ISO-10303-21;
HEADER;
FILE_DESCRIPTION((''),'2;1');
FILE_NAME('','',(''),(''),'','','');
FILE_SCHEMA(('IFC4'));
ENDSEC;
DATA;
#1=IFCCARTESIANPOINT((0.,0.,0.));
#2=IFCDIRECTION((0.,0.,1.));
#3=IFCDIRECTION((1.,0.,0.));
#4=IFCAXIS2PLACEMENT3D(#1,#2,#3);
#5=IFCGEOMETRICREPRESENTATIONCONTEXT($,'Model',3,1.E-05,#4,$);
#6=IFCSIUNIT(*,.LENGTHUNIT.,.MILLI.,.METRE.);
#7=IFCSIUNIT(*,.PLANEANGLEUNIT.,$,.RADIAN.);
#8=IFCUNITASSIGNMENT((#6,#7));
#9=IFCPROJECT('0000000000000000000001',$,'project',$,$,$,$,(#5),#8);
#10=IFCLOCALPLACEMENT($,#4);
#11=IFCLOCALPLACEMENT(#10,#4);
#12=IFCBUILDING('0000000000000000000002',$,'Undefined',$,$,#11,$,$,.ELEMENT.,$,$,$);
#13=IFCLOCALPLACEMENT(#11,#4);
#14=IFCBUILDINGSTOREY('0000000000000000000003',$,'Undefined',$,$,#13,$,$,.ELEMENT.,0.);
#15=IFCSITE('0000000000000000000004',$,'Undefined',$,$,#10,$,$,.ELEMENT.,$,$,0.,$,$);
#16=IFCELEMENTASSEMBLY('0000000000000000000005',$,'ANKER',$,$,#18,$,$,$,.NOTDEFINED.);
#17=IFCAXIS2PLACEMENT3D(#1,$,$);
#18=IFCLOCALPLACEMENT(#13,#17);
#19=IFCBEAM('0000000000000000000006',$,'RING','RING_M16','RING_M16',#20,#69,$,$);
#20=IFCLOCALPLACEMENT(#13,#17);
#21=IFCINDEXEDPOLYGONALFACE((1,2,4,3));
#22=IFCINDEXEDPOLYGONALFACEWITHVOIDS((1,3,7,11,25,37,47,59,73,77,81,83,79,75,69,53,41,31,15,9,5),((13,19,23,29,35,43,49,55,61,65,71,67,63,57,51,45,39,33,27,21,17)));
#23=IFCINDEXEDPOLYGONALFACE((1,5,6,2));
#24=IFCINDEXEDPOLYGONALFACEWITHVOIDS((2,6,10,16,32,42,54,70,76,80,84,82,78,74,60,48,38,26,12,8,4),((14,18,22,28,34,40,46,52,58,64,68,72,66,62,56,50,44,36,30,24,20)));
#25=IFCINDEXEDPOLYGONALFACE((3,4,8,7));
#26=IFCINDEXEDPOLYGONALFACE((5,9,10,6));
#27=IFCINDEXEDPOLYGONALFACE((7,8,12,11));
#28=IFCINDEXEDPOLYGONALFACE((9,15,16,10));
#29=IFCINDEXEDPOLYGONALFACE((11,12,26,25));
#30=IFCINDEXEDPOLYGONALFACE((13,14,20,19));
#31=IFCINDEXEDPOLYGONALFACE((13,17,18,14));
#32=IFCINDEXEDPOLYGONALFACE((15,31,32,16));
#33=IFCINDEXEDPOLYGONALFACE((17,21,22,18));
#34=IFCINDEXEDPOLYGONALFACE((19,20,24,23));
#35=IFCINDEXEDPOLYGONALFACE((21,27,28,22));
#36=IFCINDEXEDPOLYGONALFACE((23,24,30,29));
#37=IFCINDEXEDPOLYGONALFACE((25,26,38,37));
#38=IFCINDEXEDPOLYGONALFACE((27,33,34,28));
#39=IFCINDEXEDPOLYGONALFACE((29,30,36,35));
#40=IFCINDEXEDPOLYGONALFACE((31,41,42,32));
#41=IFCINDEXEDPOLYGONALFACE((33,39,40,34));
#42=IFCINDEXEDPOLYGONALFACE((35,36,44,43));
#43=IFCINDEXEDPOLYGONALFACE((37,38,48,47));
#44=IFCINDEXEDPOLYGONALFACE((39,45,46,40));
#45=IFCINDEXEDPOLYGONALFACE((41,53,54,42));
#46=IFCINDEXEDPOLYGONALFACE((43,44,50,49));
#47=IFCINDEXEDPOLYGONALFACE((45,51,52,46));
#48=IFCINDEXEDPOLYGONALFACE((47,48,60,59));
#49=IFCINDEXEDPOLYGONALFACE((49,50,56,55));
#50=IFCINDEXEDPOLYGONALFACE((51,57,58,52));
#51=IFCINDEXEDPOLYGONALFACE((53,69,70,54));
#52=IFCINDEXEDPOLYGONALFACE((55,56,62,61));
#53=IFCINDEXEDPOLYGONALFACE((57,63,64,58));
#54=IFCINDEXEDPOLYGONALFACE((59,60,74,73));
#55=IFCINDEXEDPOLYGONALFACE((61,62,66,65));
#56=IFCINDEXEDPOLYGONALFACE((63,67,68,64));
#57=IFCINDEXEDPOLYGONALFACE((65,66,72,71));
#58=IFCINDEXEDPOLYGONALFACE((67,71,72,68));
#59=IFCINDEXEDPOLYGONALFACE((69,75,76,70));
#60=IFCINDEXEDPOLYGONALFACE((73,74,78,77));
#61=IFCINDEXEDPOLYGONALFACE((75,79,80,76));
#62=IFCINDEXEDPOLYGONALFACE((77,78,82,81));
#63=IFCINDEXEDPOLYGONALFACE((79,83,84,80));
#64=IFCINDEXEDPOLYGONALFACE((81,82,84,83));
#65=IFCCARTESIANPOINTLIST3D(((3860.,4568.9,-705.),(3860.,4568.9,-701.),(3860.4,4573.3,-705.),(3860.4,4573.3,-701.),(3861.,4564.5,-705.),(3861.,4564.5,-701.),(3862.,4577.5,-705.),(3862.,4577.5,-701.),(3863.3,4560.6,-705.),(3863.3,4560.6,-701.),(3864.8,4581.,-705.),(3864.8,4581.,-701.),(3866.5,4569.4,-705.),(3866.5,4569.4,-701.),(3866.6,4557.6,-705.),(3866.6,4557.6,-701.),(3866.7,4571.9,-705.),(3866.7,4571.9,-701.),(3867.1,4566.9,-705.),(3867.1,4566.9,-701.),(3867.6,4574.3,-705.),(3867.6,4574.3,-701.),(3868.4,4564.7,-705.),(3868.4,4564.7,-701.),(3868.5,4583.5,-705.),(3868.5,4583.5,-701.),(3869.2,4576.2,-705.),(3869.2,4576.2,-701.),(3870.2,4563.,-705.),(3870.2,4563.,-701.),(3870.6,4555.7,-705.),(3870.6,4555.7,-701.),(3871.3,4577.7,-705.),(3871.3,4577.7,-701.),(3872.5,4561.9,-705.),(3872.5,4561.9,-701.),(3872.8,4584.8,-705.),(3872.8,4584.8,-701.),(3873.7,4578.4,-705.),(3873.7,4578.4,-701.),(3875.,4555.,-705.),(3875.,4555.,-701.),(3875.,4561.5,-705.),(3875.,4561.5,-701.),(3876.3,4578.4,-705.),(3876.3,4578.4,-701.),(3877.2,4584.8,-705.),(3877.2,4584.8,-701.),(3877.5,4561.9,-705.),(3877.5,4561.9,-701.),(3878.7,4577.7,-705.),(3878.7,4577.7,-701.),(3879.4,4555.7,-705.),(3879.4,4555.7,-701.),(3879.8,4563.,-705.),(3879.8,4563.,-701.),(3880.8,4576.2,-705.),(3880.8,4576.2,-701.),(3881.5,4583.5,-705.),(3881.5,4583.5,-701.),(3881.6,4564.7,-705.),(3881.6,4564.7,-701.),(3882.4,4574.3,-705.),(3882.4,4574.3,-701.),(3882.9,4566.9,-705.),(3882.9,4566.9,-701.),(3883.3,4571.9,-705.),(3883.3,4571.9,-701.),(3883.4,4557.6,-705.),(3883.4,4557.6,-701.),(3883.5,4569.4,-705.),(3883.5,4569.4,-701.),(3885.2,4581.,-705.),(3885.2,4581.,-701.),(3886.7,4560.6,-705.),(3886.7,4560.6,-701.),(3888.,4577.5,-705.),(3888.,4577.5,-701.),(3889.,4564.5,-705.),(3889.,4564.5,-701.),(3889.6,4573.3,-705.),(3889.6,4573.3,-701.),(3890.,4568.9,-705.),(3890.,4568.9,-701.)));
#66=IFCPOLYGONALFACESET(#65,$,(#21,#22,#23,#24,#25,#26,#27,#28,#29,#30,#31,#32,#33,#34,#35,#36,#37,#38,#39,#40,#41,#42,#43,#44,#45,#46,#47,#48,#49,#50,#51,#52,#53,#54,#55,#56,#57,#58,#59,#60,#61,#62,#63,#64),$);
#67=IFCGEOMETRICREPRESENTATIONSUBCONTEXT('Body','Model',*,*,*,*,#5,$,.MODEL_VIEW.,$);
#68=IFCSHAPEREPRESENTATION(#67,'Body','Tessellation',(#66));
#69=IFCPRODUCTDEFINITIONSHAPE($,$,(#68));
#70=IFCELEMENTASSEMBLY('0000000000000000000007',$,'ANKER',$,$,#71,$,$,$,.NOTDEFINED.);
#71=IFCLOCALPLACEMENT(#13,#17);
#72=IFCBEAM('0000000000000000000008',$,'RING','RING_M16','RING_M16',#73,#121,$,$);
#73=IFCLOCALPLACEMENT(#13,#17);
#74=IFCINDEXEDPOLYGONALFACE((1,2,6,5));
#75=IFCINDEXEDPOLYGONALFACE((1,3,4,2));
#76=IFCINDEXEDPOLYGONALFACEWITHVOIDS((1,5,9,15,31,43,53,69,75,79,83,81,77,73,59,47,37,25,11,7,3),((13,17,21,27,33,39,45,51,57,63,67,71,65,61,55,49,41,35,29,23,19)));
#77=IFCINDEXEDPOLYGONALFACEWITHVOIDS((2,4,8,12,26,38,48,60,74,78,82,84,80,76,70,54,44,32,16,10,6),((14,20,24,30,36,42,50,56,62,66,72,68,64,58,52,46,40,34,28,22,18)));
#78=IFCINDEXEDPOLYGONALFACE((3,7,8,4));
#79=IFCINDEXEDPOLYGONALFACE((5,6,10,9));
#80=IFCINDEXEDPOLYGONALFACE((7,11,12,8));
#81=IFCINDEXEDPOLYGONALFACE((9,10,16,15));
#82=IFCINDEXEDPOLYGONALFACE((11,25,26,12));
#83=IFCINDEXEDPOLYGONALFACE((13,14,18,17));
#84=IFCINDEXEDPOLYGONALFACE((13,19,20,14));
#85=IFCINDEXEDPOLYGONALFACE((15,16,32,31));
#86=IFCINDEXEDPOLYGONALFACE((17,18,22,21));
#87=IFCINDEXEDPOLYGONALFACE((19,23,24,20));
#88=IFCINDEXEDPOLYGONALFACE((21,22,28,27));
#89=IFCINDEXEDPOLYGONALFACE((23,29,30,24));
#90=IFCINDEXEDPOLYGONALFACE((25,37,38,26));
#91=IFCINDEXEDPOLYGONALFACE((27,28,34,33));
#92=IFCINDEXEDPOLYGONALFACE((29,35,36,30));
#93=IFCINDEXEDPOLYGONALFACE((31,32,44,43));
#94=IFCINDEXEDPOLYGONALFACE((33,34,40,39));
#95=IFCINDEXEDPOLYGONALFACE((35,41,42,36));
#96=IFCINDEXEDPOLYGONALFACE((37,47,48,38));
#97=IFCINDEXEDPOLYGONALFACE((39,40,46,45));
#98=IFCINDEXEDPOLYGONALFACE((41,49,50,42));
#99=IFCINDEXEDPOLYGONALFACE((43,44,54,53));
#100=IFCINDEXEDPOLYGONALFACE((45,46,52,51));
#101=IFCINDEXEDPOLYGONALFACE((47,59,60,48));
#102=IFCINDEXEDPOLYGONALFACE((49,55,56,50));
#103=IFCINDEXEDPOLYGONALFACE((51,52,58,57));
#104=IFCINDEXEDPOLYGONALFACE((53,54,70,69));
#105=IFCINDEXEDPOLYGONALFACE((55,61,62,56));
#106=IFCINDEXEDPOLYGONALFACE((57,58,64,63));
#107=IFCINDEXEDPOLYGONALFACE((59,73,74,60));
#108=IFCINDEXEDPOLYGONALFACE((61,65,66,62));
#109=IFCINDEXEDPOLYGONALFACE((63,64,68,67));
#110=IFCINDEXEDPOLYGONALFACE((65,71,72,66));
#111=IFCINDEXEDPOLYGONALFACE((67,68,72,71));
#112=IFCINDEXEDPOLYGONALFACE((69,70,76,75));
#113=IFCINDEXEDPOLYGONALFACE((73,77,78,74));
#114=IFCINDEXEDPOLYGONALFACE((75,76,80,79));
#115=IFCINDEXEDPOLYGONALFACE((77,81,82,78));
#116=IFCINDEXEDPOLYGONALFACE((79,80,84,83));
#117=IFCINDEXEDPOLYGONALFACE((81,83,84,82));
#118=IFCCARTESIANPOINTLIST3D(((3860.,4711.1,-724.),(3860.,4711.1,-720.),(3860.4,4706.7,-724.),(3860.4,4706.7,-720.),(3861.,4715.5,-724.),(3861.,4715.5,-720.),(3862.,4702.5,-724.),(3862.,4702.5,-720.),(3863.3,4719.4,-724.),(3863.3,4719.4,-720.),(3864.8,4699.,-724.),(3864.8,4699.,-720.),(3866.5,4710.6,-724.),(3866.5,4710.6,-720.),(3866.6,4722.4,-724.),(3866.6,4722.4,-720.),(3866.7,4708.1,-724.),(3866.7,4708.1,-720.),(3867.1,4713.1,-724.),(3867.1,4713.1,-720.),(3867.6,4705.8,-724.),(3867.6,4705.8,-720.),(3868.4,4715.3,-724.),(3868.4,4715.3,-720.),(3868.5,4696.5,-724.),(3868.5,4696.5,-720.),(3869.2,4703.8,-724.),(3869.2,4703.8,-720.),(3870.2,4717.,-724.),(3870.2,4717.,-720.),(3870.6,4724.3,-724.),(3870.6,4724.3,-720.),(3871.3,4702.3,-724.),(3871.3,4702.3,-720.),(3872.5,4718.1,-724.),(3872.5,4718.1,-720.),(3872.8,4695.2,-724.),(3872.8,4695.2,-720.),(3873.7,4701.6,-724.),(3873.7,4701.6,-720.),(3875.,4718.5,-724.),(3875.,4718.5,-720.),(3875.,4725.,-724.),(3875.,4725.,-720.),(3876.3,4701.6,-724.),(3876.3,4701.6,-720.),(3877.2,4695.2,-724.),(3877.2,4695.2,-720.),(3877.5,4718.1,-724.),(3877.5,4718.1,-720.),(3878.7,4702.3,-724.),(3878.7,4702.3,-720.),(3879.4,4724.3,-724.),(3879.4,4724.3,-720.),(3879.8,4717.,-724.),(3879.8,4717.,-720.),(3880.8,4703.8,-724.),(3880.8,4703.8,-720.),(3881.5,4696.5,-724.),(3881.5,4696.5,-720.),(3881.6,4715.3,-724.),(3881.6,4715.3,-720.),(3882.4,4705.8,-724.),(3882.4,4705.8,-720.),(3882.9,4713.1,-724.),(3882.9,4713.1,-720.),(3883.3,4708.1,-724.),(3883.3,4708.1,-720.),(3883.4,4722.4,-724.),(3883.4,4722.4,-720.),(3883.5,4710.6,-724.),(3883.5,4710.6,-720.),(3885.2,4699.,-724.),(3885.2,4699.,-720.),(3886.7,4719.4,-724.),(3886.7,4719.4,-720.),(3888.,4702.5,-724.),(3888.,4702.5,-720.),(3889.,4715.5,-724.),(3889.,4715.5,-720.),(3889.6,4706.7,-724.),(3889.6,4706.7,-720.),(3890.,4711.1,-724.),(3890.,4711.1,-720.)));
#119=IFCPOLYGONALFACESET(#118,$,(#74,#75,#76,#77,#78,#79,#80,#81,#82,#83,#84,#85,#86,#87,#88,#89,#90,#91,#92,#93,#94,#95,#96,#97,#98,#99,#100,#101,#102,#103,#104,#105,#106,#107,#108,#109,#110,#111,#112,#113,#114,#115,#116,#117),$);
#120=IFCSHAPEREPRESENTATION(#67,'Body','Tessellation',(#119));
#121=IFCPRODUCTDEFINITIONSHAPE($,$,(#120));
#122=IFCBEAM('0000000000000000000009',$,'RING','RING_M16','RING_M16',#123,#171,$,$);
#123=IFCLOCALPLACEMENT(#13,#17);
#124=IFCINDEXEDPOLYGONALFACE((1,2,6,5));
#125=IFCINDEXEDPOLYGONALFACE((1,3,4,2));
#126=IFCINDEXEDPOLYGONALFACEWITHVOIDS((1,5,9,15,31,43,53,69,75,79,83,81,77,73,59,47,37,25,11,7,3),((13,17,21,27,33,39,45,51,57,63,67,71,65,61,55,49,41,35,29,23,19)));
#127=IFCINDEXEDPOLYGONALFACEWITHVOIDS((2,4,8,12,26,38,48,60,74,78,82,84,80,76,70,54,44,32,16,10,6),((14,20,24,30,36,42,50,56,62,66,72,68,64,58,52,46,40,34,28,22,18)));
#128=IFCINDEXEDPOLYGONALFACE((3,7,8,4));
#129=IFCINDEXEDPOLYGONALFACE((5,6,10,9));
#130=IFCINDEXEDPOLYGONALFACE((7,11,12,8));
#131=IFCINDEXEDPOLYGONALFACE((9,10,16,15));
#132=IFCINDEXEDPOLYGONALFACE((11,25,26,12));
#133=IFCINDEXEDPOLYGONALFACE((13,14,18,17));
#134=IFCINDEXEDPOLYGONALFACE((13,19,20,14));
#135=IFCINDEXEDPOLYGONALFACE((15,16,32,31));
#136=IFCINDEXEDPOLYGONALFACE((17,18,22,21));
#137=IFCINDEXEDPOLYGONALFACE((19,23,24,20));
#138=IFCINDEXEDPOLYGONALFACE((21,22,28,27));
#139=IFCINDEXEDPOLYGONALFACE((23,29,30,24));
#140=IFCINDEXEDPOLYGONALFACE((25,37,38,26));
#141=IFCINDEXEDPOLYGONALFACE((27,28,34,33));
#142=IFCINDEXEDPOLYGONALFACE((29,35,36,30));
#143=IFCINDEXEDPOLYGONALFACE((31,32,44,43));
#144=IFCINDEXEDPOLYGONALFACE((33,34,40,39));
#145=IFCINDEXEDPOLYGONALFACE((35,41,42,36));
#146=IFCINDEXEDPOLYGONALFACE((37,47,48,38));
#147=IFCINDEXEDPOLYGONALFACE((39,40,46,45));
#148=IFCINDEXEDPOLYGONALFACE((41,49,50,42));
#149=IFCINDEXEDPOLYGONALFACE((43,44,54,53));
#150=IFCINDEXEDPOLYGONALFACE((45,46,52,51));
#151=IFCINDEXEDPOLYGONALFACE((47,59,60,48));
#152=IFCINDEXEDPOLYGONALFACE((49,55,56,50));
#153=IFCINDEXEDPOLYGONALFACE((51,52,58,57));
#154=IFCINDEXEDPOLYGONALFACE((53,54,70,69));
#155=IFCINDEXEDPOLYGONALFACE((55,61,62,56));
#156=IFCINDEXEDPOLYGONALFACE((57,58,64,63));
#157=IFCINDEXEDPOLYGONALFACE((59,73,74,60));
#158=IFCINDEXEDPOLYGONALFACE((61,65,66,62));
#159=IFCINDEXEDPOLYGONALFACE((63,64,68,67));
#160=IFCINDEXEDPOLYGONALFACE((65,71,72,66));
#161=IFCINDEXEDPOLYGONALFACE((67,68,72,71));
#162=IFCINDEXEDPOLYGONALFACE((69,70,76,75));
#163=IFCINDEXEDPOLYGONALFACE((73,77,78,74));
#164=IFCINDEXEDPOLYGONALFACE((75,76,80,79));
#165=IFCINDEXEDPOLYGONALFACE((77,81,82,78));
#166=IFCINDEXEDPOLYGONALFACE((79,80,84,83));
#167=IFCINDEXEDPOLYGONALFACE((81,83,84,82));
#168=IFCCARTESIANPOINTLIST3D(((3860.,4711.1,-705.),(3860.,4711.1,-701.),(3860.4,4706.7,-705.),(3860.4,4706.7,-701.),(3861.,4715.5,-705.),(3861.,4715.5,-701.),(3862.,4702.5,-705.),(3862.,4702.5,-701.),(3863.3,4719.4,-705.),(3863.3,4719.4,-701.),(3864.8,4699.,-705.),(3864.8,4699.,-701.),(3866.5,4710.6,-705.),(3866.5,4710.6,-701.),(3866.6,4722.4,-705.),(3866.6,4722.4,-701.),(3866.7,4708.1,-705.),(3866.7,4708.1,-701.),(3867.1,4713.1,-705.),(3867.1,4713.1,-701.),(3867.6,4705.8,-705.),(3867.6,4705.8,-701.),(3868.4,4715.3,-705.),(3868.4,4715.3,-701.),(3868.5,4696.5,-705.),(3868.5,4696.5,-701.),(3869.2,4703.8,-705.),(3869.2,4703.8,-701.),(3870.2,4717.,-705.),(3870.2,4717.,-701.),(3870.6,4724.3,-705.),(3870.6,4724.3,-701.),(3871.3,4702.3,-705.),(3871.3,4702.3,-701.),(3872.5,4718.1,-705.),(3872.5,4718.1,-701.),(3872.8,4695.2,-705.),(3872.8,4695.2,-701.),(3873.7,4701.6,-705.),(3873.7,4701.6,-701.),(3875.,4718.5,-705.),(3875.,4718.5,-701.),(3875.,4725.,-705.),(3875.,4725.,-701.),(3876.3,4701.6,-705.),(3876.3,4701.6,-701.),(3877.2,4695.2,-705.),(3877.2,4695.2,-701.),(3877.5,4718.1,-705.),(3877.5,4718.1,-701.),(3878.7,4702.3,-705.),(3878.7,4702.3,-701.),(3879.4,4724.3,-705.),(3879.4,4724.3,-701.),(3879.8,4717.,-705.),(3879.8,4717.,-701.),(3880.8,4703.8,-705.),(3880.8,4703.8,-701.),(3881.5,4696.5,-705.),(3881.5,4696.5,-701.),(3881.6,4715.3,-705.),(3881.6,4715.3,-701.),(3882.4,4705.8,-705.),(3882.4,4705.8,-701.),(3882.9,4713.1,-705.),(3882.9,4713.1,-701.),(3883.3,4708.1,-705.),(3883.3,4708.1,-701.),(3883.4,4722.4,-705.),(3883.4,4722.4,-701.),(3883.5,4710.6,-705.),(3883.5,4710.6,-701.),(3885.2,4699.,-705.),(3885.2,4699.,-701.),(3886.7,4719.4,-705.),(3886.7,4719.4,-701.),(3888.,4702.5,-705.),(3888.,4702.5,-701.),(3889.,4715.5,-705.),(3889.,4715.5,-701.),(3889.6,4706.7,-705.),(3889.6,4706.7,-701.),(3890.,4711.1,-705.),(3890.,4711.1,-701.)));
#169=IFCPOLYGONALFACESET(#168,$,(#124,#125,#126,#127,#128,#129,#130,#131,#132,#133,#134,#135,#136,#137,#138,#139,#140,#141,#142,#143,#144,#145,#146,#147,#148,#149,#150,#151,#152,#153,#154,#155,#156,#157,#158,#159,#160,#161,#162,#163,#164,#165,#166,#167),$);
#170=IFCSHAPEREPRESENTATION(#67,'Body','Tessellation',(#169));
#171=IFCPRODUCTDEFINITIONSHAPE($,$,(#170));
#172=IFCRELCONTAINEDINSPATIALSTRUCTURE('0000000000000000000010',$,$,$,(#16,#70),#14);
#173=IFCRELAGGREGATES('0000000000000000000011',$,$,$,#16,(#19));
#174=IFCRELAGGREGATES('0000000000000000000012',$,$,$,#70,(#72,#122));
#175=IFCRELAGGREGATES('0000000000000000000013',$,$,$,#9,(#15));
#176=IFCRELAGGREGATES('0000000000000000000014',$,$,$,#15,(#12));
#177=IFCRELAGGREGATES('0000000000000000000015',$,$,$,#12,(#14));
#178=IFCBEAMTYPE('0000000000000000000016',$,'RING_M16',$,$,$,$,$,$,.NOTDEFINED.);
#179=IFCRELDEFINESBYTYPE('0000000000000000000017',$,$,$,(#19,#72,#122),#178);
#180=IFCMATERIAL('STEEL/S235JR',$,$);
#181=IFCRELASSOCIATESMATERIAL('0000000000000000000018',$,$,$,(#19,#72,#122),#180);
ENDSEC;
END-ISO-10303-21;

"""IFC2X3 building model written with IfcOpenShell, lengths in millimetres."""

from ifc_helpers import new_model, si_unit, frame, origin_with_axes, origin_2d_with_axis, place, context, subcontext, project, spatial, hollow_circle, extrude, material, type_object, element, aggregate, save


model = new_model("IFC2X3")

# Units and contexts
model_context = context("Model", 3, precision=1e-05, world=origin_with_axes())
body_context = subcontext(model_context, "Body", "Model", "MODEL_VIEW")
ifc_project = project(units=[si_unit("LENGTHUNIT", "METRE", prefix="MILLI"), si_unit("PLANEANGLEUNIT", "RADIAN")], contexts=[model_context])

# Site, building, storey
site_placement = place(None, origin_with_axes())
site = spatial("IfcSite", under=ifc_project, at=site_placement, Name="Undefined", CompositionType="ELEMENT", RefElevation=0.0)
building_placement = place(site_placement, origin_with_axes())
building = spatial("IfcBuilding", under=site, at=building_placement, Name="Undefined", CompositionType="ELEMENT")
storey_placement = place(building_placement, origin_with_axes())
storey = spatial("IfcBuildingStorey", under=building, at=storey_placement, Name="Undefined", CompositionType="ELEMENT", Elevation=0.0)

# Shared definitions
ifc_material = material(Name="STEEL/S235JR")

# Element assemblies, beams
beam_type_1 = type_object("IfcBeamType", Name="RING_M16", PredefinedType="NOTDEFINED")
assembly_1_placement = place(storey_placement, frame((3875.0, 4570.0, -655.0), z_axis=(1.0, 0.0, 0.0), x_axis=(0.0, 0.0, -1.0)))
assembly_1 = element("IfcElementAssembly", 1, at=assembly_1_placement, inside=storey, Name="ANKER", PredefinedType="NOTDEFINED")
beam_1_placement = place(storey_placement, frame((3875.0, 4570.0, -701.0), z_axis=(1.0, 0.0, 0.0), x_axis=(0.0, 0.0, -1.0)))
beam_1 = element("IfcBeam", 2, at=beam_1_placement, type_object=beam_type_1, material=ifc_material, Name="RING", Description="RING_M16", ObjectType="RING_M16", context=body_context, shape_type="SweptSolid", body=[
    extrude(hollow_circle(Radius=15.0, WallThickness=6.5, at=origin_2d_with_axis()), frame((4.0, 0.0, 0.0), z_axis=(-1.0, 0.0, 0.0), x_axis=(0.0, -1.0, 0.0)), (0.0, 0.0, 1.0), 4.0),
])
aggregate(assembly_1, [beam_1])
assembly_2_placement = place(storey_placement, frame((3875.0, 4710.0, -655.0), z_axis=(-1.0, 0.0, 0.0), x_axis=(0.0, 0.0, -1.0)))
assembly_2 = element("IfcElementAssembly", 3, at=assembly_2_placement, inside=storey, Name="ANKER", PredefinedType="NOTDEFINED")
beam_2_placement = place(storey_placement, frame((3875.0, 4710.0, -720.0), z_axis=(-1.0, 0.0, 0.0), x_axis=(0.0, 0.0, -1.0)))
beam_2 = element("IfcBeam", 4, at=beam_2_placement, type_object=beam_type_1, material=ifc_material, Name="RING", Description="RING_M16", ObjectType="RING_M16", context=body_context, shape_type="SweptSolid", body=[
    extrude(hollow_circle(Radius=15.0, WallThickness=6.5, at=origin_2d_with_axis()), frame((4.0, 0.0, 0.0), z_axis=(-1.0, 0.0, 0.0), x_axis=(0.0, -1.0, 0.0)), (0.0, 0.0, 1.0), 4.0),
])
beam_3_placement = place(storey_placement, frame((3875.0, 4710.0, -701.0), z_axis=(-1.0, 0.0, 0.0), x_axis=(0.0, 0.0, -1.0)))
beam_3 = element("IfcBeam", 5, at=beam_3_placement, type_object=beam_type_1, material=ifc_material, Name="RING", Description="RING_M16", ObjectType="RING_M16", context=body_context, shape_type="SweptSolid", body=[
    extrude(hollow_circle(Radius=15.0, WallThickness=6.5, at=origin_2d_with_axis()), frame((4.0, 0.0, 0.0), z_axis=(-1.0, 0.0, 0.0), x_axis=(0.0, -1.0, 0.0)), (0.0, 0.0, 1.0), 4.0),
])
aggregate(assembly_2, [beam_2, beam_3])

save(model, "model.ifc")
